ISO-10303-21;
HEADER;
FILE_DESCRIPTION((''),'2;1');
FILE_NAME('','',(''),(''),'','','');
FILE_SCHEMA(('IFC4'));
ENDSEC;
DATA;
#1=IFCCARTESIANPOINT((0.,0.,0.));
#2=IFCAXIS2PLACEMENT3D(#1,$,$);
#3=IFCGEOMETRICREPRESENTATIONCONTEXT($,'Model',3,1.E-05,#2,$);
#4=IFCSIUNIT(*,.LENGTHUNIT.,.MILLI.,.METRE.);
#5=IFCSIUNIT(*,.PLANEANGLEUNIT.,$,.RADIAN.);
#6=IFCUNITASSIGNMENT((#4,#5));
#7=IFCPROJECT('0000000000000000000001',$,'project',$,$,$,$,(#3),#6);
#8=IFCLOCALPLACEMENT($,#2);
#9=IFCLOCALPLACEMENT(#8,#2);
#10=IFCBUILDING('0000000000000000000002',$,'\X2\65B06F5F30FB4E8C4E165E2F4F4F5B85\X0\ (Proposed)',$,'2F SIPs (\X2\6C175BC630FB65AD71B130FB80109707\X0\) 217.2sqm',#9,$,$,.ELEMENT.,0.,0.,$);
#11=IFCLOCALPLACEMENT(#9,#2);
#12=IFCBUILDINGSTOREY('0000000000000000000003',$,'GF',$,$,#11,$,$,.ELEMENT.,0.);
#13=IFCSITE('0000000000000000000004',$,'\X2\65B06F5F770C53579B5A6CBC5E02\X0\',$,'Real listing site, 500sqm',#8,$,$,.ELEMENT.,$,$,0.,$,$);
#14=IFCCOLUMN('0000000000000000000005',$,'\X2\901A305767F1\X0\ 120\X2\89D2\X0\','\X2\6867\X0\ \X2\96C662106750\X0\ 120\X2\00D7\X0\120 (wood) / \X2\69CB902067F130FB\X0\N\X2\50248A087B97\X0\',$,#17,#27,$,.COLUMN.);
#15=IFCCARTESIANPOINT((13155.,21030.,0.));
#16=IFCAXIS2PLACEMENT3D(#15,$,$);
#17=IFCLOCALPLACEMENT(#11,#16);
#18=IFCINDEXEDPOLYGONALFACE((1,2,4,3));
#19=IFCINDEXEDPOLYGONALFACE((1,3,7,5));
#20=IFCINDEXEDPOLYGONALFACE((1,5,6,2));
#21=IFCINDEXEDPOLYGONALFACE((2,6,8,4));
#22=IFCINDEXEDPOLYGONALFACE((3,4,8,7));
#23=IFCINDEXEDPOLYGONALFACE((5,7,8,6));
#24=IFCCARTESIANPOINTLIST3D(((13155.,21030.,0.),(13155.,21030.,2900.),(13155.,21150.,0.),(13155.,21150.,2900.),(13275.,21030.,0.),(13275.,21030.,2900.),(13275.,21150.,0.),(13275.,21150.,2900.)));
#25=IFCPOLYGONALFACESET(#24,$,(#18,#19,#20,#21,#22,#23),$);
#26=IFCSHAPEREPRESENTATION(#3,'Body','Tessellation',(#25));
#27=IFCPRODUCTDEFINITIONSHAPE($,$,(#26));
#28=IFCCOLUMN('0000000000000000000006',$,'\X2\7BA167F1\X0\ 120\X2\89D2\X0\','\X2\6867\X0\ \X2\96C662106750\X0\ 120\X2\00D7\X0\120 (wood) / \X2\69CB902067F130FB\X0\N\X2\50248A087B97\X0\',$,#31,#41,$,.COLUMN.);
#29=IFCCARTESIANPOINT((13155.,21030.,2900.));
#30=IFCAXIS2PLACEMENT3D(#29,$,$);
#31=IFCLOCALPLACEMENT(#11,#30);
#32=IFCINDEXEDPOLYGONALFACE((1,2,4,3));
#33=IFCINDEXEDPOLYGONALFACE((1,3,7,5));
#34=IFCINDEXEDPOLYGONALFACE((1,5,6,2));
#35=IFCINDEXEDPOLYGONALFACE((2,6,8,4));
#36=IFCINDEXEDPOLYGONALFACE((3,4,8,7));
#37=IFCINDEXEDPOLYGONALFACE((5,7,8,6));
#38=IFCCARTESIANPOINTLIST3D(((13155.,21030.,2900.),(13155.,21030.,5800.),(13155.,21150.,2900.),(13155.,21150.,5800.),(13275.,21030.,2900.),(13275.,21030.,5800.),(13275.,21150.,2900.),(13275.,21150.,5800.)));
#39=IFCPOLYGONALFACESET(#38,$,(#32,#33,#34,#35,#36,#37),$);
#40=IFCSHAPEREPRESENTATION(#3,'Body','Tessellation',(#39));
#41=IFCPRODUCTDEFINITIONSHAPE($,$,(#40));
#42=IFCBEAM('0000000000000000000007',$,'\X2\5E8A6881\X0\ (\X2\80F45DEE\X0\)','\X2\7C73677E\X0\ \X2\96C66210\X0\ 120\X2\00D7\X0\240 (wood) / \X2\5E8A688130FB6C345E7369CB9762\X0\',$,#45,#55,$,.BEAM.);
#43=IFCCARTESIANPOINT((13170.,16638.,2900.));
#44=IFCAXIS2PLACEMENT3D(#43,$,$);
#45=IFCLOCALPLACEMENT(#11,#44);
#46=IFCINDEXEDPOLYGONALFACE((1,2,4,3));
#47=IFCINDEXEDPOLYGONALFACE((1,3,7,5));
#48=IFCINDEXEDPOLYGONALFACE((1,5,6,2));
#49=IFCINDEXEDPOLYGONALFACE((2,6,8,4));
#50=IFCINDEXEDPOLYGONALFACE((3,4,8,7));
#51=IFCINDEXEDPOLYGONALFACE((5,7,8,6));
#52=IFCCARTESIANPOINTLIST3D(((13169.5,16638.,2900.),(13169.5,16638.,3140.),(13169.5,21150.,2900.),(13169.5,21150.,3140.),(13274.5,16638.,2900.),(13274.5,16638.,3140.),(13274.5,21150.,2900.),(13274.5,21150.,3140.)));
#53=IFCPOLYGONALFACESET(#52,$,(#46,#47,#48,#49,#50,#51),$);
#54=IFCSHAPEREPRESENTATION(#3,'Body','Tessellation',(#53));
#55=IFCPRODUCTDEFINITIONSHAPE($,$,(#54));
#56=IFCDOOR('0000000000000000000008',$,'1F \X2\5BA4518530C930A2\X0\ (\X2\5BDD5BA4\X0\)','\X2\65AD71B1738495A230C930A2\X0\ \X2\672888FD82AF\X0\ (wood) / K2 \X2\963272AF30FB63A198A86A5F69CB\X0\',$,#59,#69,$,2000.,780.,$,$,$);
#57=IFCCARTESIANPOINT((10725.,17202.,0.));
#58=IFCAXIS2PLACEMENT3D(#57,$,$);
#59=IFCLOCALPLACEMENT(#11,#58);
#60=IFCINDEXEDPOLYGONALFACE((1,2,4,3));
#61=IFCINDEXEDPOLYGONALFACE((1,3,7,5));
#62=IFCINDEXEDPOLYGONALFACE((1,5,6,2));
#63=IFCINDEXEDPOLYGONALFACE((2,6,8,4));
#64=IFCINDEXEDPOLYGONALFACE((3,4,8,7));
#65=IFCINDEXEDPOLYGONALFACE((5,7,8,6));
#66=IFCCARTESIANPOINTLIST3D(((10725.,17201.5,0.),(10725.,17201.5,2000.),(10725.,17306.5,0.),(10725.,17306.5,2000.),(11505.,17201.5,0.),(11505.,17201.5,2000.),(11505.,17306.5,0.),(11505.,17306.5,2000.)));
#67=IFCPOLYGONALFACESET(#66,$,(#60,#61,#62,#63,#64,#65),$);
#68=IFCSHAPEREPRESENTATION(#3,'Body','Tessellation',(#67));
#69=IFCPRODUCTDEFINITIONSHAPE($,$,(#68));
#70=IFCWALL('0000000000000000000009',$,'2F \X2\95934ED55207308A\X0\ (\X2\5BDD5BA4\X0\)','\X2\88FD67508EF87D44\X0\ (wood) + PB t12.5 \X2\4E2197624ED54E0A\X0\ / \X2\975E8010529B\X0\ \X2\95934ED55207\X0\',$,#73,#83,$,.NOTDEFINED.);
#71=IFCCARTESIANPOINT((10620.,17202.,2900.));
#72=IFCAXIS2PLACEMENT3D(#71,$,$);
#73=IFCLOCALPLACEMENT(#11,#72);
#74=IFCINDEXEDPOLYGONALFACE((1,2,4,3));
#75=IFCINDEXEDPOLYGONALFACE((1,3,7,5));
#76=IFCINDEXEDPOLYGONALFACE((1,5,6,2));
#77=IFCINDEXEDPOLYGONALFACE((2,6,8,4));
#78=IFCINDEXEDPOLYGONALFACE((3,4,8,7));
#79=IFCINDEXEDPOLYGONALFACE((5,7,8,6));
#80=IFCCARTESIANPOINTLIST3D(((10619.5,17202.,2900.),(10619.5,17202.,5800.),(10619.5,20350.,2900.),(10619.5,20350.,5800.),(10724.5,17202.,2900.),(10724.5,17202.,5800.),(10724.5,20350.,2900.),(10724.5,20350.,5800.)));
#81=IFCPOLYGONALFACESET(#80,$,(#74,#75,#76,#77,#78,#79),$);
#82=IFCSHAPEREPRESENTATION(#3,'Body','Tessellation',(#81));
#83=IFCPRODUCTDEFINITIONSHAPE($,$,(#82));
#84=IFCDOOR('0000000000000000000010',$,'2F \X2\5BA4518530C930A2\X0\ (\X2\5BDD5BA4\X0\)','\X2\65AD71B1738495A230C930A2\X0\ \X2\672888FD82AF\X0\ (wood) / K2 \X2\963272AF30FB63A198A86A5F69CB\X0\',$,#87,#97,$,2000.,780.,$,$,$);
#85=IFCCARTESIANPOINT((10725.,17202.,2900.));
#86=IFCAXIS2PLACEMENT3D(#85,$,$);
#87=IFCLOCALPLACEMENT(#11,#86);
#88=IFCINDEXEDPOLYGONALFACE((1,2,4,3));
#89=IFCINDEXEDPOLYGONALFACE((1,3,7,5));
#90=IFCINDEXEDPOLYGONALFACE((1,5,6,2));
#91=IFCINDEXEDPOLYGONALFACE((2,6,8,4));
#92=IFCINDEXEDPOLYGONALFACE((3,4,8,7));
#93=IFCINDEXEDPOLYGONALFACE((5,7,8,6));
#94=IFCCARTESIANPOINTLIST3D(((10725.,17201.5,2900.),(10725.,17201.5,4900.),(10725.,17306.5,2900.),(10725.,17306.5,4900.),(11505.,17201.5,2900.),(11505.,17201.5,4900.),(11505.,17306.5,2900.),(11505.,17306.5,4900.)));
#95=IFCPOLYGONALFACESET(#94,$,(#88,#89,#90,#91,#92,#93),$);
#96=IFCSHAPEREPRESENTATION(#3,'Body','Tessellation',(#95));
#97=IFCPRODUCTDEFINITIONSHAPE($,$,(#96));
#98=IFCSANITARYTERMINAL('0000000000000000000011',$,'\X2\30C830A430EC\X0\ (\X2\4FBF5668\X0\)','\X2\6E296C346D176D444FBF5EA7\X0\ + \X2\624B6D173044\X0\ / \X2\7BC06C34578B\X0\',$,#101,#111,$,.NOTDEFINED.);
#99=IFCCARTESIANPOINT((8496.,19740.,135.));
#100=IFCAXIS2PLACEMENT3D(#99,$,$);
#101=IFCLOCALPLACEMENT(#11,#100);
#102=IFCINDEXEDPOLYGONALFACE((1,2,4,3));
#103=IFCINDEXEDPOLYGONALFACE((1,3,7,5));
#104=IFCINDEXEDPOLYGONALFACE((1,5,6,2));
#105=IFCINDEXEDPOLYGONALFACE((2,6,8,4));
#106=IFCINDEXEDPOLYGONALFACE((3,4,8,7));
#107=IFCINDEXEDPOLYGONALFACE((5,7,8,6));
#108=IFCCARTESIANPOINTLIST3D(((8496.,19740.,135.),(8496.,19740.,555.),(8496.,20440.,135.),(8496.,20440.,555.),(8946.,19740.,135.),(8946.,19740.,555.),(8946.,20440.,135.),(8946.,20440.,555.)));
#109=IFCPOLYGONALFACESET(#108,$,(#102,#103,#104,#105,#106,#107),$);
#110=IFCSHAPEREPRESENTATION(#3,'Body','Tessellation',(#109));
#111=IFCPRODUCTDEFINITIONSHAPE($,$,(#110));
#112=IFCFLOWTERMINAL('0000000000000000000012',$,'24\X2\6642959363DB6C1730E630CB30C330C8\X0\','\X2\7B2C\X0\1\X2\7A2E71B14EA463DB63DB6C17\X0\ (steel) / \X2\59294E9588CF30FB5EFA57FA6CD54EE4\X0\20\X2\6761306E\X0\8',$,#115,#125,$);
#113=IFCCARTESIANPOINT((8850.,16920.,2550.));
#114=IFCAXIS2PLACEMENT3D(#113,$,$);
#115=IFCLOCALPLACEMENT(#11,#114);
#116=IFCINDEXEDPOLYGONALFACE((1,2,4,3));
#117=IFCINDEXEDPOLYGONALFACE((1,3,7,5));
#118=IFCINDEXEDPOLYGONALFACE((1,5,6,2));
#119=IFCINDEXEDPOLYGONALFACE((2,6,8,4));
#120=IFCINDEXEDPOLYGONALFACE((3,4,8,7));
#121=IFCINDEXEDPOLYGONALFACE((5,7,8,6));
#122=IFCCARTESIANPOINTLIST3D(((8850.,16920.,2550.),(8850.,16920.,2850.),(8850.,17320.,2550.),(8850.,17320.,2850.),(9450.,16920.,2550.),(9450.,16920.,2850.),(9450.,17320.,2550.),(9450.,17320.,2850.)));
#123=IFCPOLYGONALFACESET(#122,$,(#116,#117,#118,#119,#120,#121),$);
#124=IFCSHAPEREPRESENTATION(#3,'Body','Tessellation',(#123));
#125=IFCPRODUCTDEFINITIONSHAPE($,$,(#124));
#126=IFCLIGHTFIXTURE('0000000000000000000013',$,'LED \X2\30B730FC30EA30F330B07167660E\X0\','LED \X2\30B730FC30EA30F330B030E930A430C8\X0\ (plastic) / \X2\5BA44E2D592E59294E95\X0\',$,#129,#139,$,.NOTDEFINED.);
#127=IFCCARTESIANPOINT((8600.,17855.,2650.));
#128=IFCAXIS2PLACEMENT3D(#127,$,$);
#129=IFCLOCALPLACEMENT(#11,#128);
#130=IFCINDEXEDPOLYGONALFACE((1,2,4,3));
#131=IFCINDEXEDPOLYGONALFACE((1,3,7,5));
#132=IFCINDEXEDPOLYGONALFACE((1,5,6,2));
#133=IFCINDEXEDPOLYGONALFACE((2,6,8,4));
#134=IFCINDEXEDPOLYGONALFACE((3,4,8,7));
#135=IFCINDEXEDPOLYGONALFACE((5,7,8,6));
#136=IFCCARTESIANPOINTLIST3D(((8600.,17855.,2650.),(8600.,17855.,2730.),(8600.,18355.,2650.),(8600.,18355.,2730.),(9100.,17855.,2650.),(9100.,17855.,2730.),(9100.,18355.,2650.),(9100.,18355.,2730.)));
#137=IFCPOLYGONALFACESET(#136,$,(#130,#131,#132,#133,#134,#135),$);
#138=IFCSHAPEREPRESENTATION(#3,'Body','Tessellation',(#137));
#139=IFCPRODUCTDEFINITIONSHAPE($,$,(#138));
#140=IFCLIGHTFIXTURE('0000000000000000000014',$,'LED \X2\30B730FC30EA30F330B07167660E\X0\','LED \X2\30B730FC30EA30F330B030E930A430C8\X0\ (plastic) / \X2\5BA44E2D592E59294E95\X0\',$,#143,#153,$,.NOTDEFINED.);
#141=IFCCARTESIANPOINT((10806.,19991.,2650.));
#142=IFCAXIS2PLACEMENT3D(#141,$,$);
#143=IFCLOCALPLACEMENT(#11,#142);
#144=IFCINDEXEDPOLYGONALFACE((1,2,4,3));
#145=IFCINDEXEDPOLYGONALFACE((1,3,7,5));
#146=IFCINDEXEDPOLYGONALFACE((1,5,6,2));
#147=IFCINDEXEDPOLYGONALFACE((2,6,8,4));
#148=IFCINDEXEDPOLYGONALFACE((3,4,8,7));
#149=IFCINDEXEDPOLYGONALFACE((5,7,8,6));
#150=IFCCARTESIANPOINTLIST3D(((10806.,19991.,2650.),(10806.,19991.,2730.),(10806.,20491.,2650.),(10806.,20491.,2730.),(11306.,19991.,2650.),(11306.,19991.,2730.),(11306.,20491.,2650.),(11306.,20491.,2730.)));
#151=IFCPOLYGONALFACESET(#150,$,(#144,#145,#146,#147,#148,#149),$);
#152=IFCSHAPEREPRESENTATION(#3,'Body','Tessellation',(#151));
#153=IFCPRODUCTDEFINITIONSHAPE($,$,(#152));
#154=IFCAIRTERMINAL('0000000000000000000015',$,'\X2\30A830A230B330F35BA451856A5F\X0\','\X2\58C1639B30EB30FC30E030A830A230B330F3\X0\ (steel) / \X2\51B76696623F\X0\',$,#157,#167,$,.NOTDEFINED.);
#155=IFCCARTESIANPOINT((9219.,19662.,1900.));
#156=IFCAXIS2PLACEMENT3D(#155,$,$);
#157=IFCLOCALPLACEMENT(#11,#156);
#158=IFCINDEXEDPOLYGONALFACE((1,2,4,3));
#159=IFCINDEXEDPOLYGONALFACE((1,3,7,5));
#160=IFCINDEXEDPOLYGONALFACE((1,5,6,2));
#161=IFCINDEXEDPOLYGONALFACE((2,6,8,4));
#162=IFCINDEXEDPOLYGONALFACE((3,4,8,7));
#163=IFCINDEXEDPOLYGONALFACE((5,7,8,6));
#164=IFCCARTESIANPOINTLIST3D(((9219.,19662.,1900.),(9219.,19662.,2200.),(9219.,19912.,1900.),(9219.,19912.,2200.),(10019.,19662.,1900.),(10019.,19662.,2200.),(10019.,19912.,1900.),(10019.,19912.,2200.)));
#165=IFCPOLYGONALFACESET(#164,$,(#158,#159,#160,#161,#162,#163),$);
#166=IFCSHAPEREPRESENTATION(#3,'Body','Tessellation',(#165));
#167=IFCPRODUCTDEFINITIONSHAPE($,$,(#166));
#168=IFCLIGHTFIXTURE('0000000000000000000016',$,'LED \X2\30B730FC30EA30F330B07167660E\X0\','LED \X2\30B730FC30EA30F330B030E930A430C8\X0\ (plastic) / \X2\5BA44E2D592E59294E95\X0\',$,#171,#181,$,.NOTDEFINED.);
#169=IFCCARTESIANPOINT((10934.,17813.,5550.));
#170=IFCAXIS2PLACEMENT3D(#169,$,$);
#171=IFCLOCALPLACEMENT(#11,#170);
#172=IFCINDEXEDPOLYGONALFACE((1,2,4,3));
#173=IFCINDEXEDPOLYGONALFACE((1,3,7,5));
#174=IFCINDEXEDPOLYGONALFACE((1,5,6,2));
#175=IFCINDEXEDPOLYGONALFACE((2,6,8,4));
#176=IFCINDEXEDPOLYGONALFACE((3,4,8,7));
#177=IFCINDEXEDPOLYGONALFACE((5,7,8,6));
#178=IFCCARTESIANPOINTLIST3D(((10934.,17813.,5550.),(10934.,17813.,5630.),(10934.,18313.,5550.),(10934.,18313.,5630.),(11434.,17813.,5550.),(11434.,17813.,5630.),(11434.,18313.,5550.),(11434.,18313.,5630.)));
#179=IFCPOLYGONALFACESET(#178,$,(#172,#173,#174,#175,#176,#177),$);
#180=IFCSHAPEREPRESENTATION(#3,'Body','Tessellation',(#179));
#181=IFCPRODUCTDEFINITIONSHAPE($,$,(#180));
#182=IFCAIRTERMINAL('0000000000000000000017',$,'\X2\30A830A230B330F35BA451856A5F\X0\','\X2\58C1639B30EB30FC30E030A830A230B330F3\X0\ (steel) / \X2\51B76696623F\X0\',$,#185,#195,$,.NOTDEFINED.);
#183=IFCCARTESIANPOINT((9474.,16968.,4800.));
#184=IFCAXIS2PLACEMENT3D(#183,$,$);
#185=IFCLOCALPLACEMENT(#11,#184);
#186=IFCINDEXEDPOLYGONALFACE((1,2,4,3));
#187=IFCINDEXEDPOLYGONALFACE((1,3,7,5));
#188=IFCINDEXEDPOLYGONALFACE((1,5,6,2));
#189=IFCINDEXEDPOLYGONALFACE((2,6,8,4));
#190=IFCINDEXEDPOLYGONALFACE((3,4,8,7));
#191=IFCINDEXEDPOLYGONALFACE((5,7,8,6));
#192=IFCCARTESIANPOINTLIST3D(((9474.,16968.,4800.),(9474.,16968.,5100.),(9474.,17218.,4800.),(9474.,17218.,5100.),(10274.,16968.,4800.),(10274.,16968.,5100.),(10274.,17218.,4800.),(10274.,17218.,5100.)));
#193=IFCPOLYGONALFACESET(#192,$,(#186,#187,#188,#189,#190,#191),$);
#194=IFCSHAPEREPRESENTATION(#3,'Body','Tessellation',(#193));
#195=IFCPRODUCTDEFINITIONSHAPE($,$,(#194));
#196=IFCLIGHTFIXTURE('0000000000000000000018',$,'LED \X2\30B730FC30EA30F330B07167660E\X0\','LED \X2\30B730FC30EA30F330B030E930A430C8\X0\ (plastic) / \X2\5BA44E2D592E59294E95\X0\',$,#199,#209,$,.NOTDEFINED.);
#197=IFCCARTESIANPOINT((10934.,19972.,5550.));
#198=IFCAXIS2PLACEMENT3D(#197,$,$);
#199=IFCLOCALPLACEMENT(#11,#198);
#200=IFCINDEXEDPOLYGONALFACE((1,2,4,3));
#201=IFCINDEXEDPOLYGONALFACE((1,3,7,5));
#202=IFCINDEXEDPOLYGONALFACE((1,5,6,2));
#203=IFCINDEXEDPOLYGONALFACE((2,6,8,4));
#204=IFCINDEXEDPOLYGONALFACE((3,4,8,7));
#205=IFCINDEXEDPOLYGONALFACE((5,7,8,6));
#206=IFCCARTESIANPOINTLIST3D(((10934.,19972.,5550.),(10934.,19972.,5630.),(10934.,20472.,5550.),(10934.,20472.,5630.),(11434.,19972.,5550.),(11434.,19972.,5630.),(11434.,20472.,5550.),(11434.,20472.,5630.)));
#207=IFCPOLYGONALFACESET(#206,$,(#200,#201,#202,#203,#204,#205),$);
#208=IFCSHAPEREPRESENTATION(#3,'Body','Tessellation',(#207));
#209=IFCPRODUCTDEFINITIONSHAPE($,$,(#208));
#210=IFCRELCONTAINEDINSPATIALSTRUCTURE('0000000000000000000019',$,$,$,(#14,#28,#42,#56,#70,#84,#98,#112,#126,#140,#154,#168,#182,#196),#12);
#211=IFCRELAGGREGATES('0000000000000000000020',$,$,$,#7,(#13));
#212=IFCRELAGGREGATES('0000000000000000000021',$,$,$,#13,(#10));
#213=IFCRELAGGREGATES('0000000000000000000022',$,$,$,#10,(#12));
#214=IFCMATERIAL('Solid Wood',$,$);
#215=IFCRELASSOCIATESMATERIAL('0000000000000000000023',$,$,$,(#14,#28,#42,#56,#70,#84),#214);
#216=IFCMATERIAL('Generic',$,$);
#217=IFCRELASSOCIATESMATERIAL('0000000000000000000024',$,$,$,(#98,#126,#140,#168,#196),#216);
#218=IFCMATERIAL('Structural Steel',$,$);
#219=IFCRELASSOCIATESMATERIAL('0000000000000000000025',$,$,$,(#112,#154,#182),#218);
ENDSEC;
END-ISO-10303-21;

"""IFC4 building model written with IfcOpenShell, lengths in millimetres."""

from ifc_helpers import new_model, si_unit, frame, frame_2d, origin, place, context, project, spatial, rectangle, extrude, material, element, save


model = new_model("IFC4")

# Units and contexts
model_context = context("Model", 3, precision=1e-05, world=origin())
ifc_project = project(units=[si_unit("LENGTHUNIT", "METRE", prefix="MILLI"), si_unit("PLANEANGLEUNIT", "RADIAN")], contexts=[model_context])

# Site, building, storey
site_placement = place(None, origin())
site = spatial("IfcSite", under=ifc_project, at=site_placement, Name="新潟県南魚沼市", ObjectType="Real listing site, 500sqm", CompositionType="ELEMENT", RefElevation=0.0)
building_placement = place(site_placement, origin())
building = spatial("IfcBuilding", under=site, at=building_placement, Name="新潟・二世帯住宅 (Proposed)", ObjectType="2F SIPs (気密・断熱・耐震) 217.2sqm", CompositionType="ELEMENT", ElevationOfRefHeight=0.0, ElevationOfTerrain=0.0)
storey_placement = place(building_placement, origin())
storey = spatial("IfcBuildingStorey", under=building, at=storey_placement, Name="GF", CompositionType="ELEMENT", Elevation=0.0)

# Columns
ifc_material_1 = material(Name="Solid Wood")
column_1_placement = place(storey_placement, frame((13155.0, 21030.0, 0.0)))
element("IfcColumn", 1, at=column_1_placement, inside=storey, material=ifc_material_1, Name="通し柱 120角", Description="桧 集成材 120×120 (wood) / 構造柱・N値計算", PredefinedType="COLUMN", context=model_context, shape_type="SweptSolid", body=[
    extrude(rectangle(XDim=120.0, YDim=120.0, at=frame_2d((60.0, 60.0))), frame((13155.0, 21030.0, 0.0)), (0.0, 0.0, 1.0), 2900.0),
])
column_2_placement = place(storey_placement, frame((13155.0, 21030.0, 2900.0)))
element("IfcColumn", 2, at=column_2_placement, inside=storey, material=ifc_material_1, Name="管柱 120角", Description="桧 集成材 120×120 (wood) / 構造柱・N値計算", PredefinedType="COLUMN", context=model_context, shape_type="SweptSolid", body=[
    extrude(rectangle(XDim=120.0, YDim=120.0, at=frame_2d((60.0, 60.0))), frame((13155.0, 21030.0, 2900.0)), (0.0, 0.0, 1.0), 2900.0),
])

# Beam
beam_1_placement = place(storey_placement, frame((13170.0, 16638.0, 2900.0)))
element("IfcBeam", 3, at=beam_1_placement, inside=storey, material=ifc_material_1, Name="床梁 (胴差)", Description="米松 集成 120×240 (wood) / 床梁・水平構面", PredefinedType="BEAM", context=model_context, shape_type="SweptSolid", body=[
    extrude(rectangle(XDim=105.0, YDim=4512.0, at=frame_2d((52.0, 2256.0))), frame((13170.0, 16638.0, 2900.0)), (0.0, 0.0, 1.0), 240.0),
])

# Door
door_1_placement = place(storey_placement, frame((10725.0, 17202.0, 0.0)))
element("IfcDoor", 4, at=door_1_placement, inside=storey, material=ifc_material_1, Name="1F 室内ドア (寝室)", Description="断熱玄関ドア 木製芯 (wood) / K2 防犯・採風機構", OverallHeight=2000.0, OverallWidth=780.0, context=model_context, shape_type="SweptSolid", body=[
    extrude(rectangle(XDim=780.0, YDim=105.0, at=frame_2d((390.0, 52.0))), frame((10725.0, 17202.0, 0.0)), (0.0, 0.0, 1.0), 2000.0),
])

# Wall
wall_1_placement = place(storey_placement, frame((10620.0, 17202.0, 2900.0)))
element("IfcWall", 5, at=wall_1_placement, inside=storey, material=ifc_material_1, Name="2F 間仕切り (寝室)", Description="製材軸組 (wood) + PB t12.5 両面仕上 / 非耐力 間仕切", PredefinedType="NOTDEFINED", context=model_context, shape_type="SweptSolid", body=[
    extrude(rectangle(XDim=105.0, YDim=3148.0, at=frame_2d((52.0, 1574.0))), frame((10620.0, 17202.0, 2900.0)), (0.0, 0.0, 1.0), 2900.0),
])

# Door
door_2_placement = place(storey_placement, frame((10725.0, 17202.0, 2900.0)))
element("IfcDoor", 6, at=door_2_placement, inside=storey, material=ifc_material_1, Name="2F 室内ドア (寝室)", Description="断熱玄関ドア 木製芯 (wood) / K2 防犯・採風機構", OverallHeight=2000.0, OverallWidth=780.0, context=model_context, shape_type="SweptSolid", body=[
    extrude(rectangle(XDim=780.0, YDim=105.0, at=frame_2d((390.0, 52.0))), frame((10725.0, 17202.0, 2900.0)), (0.0, 0.0, 1.0), 2000.0),
])

# Sanitary terminal
ifc_material_2 = material(Name="Generic")
sanitary_terminal_placement = place(storey_placement, frame((8496.0, 19740.0, 135.0)))
element("IfcSanitaryTerminal", 7, at=sanitary_terminal_placement, inside=storey, material=ifc_material_2, Name="トイレ (便器)", Description="温水洗浄便座 + 手洗い / 節水型", PredefinedType="NOTDEFINED", context=model_context, shape_type="SweptSolid", body=[
    extrude(rectangle(XDim=450.0, YDim=700.0, at=frame_2d((225.0, 350.0))), frame((8496.0, 19740.0, 135.0)), (0.0, 0.0, 1.0), 420.0),
])

# Flow terminal
ifc_material_3 = material(Name="Structural Steel")
flow_terminal_placement = place(storey_placement, frame((8850.0, 16920.0, 2550.0)))
element("IfcFlowTerminal", 8, at=flow_terminal_placement, inside=storey, material=ifc_material_3, Name="24時間換気ユニット", Description="第1種熱交換換気 (steel) / 天井裏・建基法令20条の8", context=model_context, shape_type="SweptSolid", body=[
    extrude(rectangle(XDim=600.0, YDim=400.0, at=frame_2d((300.0, 200.0))), frame((8850.0, 16920.0, 2550.0)), (0.0, 0.0, 1.0), 300.0),
])

# Light fixtures
light_fixture_1_placement = place(storey_placement, frame((8600.0, 17855.0, 2650.0)))
element("IfcLightFixture", 9, at=light_fixture_1_placement, inside=storey, material=ifc_material_2, Name="LED シーリング照明", Description="LED シーリングライト (plastic) / 室中央天井", PredefinedType="NOTDEFINED", context=model_context, shape_type="SweptSolid", body=[
    extrude(rectangle(XDim=500.0, YDim=500.0, at=frame_2d((250.0, 250.0))), frame((8600.0, 17855.0, 2650.0)), (0.0, 0.0, 1.0), 80.0),
])
light_fixture_2_placement = place(storey_placement, frame((10806.0, 19991.0, 2650.0)))
element("IfcLightFixture", 10, at=light_fixture_2_placement, inside=storey, material=ifc_material_2, Name="LED シーリング照明", Description="LED シーリングライト (plastic) / 室中央天井", PredefinedType="NOTDEFINED", context=model_context, shape_type="SweptSolid", body=[
    extrude(rectangle(XDim=500.0, YDim=500.0, at=frame_2d((250.0, 250.0))), frame((10806.0, 19991.0, 2650.0)), (0.0, 0.0, 1.0), 80.0),
])

# Air terminal
air_terminal_1_placement = place(storey_placement, frame((9219.0, 19662.0, 1900.0)))
element("IfcAirTerminal", 11, at=air_terminal_1_placement, inside=storey, material=ifc_material_3, Name="エアコン室内機", Description="壁掛ルームエアコン (steel) / 冷暖房", PredefinedType="NOTDEFINED", context=model_context, shape_type="SweptSolid", body=[
    extrude(rectangle(XDim=800.0, YDim=250.0, at=frame_2d((400.0, 125.0))), frame((9219.0, 19662.0, 1900.0)), (0.0, 0.0, 1.0), 300.0),
])

# Light fixture
light_fixture_3_placement = place(storey_placement, frame((10934.0, 17813.0, 5550.0)))
element("IfcLightFixture", 12, at=light_fixture_3_placement, inside=storey, material=ifc_material_2, Name="LED シーリング照明", Description="LED シーリングライト (plastic) / 室中央天井", PredefinedType="NOTDEFINED", context=model_context, shape_type="SweptSolid", body=[
    extrude(rectangle(XDim=500.0, YDim=500.0, at=frame_2d((250.0, 250.0))), frame((10934.0, 17813.0, 5550.0)), (0.0, 0.0, 1.0), 80.0),
])

# Air terminal
air_terminal_2_placement = place(storey_placement, frame((9474.0, 16968.0, 4800.0)))
element("IfcAirTerminal", 13, at=air_terminal_2_placement, inside=storey, material=ifc_material_3, Name="エアコン室内機", Description="壁掛ルームエアコン (steel) / 冷暖房", PredefinedType="NOTDEFINED", context=model_context, shape_type="SweptSolid", body=[
    extrude(rectangle(XDim=800.0, YDim=250.0, at=frame_2d((400.0, 125.0))), frame((9474.0, 16968.0, 4800.0)), (0.0, 0.0, 1.0), 300.0),
])

# Light fixture
light_fixture_4_placement = place(storey_placement, frame((10934.0, 19972.0, 5550.0)))
element("IfcLightFixture", 14, at=light_fixture_4_placement, inside=storey, material=ifc_material_2, Name="LED シーリング照明", Description="LED シーリングライト (plastic) / 室中央天井", PredefinedType="NOTDEFINED", context=model_context, shape_type="SweptSolid", body=[
    extrude(rectangle(XDim=500.0, YDim=500.0, at=frame_2d((250.0, 250.0))), frame((10934.0, 19972.0, 5550.0)), (0.0, 0.0, 1.0), 80.0),
])

save(model, "model.ifc")
